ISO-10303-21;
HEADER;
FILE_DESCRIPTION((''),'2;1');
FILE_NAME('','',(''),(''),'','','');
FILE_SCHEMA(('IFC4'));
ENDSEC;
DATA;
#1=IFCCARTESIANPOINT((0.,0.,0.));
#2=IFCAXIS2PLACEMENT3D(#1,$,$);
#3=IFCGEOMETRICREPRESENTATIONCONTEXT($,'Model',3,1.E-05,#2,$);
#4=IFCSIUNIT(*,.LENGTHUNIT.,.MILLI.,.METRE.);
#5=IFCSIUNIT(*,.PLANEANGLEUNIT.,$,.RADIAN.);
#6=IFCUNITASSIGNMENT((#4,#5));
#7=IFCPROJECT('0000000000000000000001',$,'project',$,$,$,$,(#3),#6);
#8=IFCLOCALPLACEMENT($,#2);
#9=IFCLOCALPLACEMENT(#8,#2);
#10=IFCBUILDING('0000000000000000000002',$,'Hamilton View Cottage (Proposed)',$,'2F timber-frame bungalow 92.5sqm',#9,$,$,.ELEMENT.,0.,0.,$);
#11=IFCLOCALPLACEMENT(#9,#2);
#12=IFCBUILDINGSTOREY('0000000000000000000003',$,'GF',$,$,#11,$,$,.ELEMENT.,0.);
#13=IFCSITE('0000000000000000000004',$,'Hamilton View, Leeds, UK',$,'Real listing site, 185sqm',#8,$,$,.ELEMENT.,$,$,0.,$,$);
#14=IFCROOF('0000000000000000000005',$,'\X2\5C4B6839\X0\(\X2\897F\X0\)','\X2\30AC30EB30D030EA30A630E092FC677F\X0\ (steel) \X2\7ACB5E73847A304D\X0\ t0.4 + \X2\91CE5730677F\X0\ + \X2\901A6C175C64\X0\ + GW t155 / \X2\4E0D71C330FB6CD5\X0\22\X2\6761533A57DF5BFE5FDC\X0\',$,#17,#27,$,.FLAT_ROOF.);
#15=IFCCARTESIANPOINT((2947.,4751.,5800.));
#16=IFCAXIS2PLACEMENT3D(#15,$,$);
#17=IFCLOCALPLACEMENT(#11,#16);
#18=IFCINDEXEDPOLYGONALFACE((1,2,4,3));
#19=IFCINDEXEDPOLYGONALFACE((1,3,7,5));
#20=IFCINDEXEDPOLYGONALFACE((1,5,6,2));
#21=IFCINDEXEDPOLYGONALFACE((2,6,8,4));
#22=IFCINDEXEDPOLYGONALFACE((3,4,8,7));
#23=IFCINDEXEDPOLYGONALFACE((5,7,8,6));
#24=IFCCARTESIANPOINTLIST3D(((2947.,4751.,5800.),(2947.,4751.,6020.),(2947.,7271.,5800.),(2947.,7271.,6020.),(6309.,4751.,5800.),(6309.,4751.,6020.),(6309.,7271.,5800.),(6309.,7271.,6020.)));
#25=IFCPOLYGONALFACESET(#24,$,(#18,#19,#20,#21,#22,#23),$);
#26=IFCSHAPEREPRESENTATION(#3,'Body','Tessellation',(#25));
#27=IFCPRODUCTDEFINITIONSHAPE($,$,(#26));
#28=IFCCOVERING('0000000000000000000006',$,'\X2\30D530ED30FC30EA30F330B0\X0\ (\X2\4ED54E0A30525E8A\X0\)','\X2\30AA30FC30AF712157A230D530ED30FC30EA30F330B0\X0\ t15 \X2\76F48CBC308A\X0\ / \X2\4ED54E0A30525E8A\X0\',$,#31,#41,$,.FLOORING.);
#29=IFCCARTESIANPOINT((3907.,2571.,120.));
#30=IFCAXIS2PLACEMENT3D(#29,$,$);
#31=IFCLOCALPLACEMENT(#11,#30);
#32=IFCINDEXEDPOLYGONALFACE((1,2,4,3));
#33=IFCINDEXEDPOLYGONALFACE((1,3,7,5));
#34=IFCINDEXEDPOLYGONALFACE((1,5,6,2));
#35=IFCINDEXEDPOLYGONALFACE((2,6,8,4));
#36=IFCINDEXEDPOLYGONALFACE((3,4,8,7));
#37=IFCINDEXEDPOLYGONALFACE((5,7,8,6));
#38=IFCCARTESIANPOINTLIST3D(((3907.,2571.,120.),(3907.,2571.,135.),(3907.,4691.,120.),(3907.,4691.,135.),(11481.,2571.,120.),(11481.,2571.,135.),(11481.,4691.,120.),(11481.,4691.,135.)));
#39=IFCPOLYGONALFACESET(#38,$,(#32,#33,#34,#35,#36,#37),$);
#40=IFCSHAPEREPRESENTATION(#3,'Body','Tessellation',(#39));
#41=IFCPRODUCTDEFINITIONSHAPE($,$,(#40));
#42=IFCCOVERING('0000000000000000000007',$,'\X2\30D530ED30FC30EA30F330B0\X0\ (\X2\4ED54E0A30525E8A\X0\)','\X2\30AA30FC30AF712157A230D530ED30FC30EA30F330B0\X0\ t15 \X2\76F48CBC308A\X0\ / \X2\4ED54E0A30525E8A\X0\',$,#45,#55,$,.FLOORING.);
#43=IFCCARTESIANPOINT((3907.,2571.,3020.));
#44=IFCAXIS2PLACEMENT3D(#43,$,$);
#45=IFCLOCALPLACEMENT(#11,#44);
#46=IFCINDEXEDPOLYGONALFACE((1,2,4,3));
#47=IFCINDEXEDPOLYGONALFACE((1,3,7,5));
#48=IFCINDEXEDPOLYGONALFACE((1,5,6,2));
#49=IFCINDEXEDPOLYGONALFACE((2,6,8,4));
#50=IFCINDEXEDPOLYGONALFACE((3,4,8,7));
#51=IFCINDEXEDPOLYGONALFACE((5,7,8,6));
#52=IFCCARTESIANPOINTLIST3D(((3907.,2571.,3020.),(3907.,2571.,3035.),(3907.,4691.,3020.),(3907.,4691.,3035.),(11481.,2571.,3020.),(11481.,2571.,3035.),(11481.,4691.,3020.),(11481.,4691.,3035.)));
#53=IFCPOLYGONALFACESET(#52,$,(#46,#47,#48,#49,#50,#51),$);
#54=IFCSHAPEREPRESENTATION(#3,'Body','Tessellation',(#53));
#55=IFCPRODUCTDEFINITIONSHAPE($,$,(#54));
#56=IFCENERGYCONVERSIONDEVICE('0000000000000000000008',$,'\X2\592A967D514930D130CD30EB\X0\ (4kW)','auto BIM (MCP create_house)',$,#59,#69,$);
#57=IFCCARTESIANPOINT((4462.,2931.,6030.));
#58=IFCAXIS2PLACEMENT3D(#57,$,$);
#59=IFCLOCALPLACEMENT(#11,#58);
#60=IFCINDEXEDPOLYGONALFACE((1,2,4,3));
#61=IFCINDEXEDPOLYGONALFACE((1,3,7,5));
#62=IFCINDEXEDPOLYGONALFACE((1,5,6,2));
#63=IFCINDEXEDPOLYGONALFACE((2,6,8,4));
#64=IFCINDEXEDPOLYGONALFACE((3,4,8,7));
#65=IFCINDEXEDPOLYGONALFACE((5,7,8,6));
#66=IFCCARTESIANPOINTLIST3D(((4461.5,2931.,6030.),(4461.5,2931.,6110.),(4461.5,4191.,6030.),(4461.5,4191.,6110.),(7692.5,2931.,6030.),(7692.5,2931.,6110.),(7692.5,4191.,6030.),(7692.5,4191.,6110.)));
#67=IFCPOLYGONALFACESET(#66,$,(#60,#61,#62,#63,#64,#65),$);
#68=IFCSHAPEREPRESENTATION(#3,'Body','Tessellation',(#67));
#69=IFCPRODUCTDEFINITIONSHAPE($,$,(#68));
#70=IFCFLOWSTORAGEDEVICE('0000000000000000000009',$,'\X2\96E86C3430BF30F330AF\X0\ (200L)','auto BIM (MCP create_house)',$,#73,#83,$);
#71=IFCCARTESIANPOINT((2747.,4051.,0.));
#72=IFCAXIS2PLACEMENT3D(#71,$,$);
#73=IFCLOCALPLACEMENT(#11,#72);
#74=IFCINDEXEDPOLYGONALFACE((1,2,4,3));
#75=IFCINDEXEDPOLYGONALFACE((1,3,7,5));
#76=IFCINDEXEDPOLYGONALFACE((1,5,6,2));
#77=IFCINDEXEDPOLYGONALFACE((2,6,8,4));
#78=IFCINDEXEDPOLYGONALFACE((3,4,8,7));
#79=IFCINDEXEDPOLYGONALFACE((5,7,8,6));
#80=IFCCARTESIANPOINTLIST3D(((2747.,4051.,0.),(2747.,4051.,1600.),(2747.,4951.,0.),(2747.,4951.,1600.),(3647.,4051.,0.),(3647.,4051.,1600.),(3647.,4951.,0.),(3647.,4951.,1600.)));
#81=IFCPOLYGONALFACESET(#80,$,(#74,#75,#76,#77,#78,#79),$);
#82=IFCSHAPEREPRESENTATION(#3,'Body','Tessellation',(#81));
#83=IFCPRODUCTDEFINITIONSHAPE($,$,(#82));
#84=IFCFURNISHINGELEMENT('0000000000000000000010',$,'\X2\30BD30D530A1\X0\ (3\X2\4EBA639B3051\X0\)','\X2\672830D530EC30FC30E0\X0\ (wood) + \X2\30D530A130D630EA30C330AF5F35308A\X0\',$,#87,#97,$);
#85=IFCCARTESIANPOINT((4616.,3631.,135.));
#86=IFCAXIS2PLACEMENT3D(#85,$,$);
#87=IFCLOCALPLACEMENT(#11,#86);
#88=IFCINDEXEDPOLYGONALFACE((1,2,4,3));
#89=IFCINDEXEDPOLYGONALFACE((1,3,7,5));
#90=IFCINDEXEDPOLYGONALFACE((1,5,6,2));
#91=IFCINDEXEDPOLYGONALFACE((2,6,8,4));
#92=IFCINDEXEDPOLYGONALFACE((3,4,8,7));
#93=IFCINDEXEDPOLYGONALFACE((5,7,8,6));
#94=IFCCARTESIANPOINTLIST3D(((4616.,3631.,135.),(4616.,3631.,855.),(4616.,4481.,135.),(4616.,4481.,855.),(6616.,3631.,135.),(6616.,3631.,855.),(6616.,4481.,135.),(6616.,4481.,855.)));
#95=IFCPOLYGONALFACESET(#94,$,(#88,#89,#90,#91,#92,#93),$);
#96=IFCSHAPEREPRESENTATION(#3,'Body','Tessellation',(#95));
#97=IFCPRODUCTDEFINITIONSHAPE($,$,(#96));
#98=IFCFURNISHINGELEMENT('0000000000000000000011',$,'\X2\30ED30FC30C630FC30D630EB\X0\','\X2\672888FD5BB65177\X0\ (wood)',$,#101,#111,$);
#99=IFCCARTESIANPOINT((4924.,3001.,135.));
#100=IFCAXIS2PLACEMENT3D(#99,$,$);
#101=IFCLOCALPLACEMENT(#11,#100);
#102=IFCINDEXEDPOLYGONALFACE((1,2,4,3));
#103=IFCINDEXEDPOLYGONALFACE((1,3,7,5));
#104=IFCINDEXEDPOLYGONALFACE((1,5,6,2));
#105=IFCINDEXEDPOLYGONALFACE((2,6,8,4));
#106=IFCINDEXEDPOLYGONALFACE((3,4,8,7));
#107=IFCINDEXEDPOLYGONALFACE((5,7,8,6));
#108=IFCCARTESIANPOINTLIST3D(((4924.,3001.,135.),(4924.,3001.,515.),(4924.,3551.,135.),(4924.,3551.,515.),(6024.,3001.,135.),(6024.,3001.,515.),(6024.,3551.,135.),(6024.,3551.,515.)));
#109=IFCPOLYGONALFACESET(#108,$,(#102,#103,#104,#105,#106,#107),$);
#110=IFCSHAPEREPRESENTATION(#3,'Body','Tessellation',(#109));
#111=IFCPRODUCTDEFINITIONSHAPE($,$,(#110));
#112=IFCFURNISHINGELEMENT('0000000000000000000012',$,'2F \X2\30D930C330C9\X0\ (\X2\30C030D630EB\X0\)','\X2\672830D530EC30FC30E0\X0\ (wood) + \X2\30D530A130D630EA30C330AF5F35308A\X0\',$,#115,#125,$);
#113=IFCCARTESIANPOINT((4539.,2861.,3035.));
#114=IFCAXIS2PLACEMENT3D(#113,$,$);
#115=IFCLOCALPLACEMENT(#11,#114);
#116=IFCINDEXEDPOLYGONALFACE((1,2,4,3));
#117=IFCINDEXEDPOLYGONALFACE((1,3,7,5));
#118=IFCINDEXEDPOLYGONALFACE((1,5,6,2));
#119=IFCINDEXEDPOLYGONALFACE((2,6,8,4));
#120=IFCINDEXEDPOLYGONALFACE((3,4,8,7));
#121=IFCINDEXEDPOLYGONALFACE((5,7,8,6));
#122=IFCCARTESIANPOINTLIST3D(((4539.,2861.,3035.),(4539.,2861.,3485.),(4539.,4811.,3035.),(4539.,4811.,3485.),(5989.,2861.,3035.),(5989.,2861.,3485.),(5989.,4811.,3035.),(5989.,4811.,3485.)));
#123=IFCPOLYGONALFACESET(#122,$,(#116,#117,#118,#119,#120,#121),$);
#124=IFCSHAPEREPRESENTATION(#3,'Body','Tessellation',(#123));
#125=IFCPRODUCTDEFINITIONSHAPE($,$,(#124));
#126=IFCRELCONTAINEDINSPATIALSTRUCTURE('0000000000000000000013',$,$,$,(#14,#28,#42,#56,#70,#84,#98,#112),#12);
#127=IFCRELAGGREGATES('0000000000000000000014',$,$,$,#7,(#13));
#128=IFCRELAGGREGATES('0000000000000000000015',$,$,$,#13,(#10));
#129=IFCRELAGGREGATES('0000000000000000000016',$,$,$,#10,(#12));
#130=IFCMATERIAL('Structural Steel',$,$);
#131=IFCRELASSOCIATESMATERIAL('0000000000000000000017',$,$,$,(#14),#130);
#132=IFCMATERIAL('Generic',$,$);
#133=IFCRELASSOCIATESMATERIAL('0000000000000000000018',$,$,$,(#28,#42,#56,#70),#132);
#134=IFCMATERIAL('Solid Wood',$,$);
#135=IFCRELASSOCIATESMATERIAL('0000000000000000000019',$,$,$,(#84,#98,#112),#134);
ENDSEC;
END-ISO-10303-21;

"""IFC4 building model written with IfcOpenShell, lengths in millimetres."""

from ifc_helpers import new_model, si_unit, frame, frame_2d, origin, place, context, project, spatial, rectangle, extrude, material, element, save


model = new_model("IFC4")

# Units and contexts
model_context = context("Model", 3, precision=1e-05, world=origin())
ifc_project = project(units=[si_unit("LENGTHUNIT", "METRE", prefix="MILLI"), si_unit("PLANEANGLEUNIT", "RADIAN")], contexts=[model_context])

# Site, building, storey
site_placement = place(None, origin())
site = spatial("IfcSite", under=ifc_project, at=site_placement, Name="Hamilton View, Leeds, UK", ObjectType="Real listing site, 185sqm", CompositionType="ELEMENT", RefElevation=0.0)
building_placement = place(site_placement, origin())
building = spatial("IfcBuilding", under=site, at=building_placement, Name="Hamilton View Cottage (Proposed)", ObjectType="2F timber-frame bungalow 92.5sqm", CompositionType="ELEMENT", ElevationOfRefHeight=0.0, ElevationOfTerrain=0.0)
storey_placement = place(building_placement, origin())
storey = spatial("IfcBuildingStorey", under=building, at=storey_placement, Name="GF", CompositionType="ELEMENT", Elevation=0.0)

# Shared definitions
ifc_material_1 = material(Name="Solid Wood")

# Roof
ifc_material_2 = material(Name="Structural Steel")
roof_1_placement = place(storey_placement, frame((2947.0, 4751.0, 5800.0)))
element("IfcRoof", 1, at=roof_1_placement, inside=storey, material=ifc_material_2, Name="屋根(西)", Description="ガルバリウム鋼板 (steel) 立平葺き t0.4 + 野地板 + 通気層 + GW t155 / 不燃・法22条区域対応", PredefinedType="FLAT_ROOF", context=model_context, shape_type="SweptSolid", body=[
    extrude(rectangle(XDim=3362.0, YDim=2520.0, at=frame_2d((1681.0, 1260.0))), frame((2947.0, 4751.0, 5800.0)), (0.0, 0.0, 1.0), 220.0),
])

# Coverings
ifc_material_3 = material(Name="Generic")
covering_1_placement = place(storey_placement, frame((3907.0, 2571.0, 120.0)))
element("IfcCovering", 2, at=covering_1_placement, inside=storey, material=ifc_material_3, Name="フローリング (仕上げ床)", Description="オーク無垢フローリング t15 直貼り / 仕上げ床", PredefinedType="FLOORING", context=model_context, shape_type="SweptSolid", body=[
    extrude(rectangle(XDim=7574.0, YDim=2120.0, at=frame_2d((3787.0, 1060.0))), frame((3907.0, 2571.0, 120.0)), (0.0, 0.0, 1.0), 15.0),
])
covering_2_placement = place(storey_placement, frame((3907.0, 2571.0, 3020.0)))
element("IfcCovering", 3, at=covering_2_placement, inside=storey, material=ifc_material_3, Name="フローリング (仕上げ床)", Description="オーク無垢フローリング t15 直貼り / 仕上げ床", PredefinedType="FLOORING", context=model_context, shape_type="SweptSolid", body=[
    extrude(rectangle(XDim=7574.0, YDim=2120.0, at=frame_2d((3787.0, 1060.0))), frame((3907.0, 2571.0, 3020.0)), (0.0, 0.0, 1.0), 15.0),
])

# Energy conversion device
energy_conversion_device_placement = place(storey_placement, frame((4462.0, 2931.0, 6030.0)))
element("IfcEnergyConversionDevice", 4, at=energy_conversion_device_placement, inside=storey, material=ifc_material_3, Name="太陽光パネル (4kW)", Description="auto BIM (MCP create_house)", context=model_context, shape_type="SweptSolid", body=[
    extrude(rectangle(XDim=3231.0, YDim=1260.0, at=frame_2d((1615.0, 630.0))), frame((4462.0, 2931.0, 6030.0)), (0.0, 0.0, 1.0), 80.0),
])

# Flow storage device
flow_storage_device_placement = place(storey_placement, frame((2747.0, 4051.0, 0.0)))
element("IfcFlowStorageDevice", 5, at=flow_storage_device_placement, inside=storey, material=ifc_material_3, Name="雨水タンク (200L)", Description="auto BIM (MCP create_house)", context=model_context, shape_type="SweptSolid", body=[
    extrude(rectangle(XDim=900.0, YDim=900.0, at=frame_2d((450.0, 450.0))), frame((2747.0, 4051.0, 0.0)), (0.0, 0.0, 1.0), 1600.0),
])

# Furnishing elements
furnishing_1_placement = place(storey_placement, frame((4616.0, 3631.0, 135.0)))
element("IfcFurnishingElement", 6, at=furnishing_1_placement, inside=storey, material=ifc_material_1, Name="ソファ (3人掛け)", Description="木フレーム (wood) + ファブリック張り", context=model_context, shape_type="SweptSolid", body=[
    extrude(rectangle(XDim=2000.0, YDim=850.0, at=frame_2d((1000.0, 425.0))), frame((4616.0, 3631.0, 135.0)), (0.0, 0.0, 1.0), 720.0),
])
furnishing_2_placement = place(storey_placement, frame((4924.0, 3001.0, 135.0)))
element("IfcFurnishingElement", 7, at=furnishing_2_placement, inside=storey, material=ifc_material_1, Name="ローテーブル", Description="木製家具 (wood)", context=model_context, shape_type="SweptSolid", body=[
    extrude(rectangle(XDim=1100.0, YDim=550.0, at=frame_2d((550.0, 275.0))), frame((4924.0, 3001.0, 135.0)), (0.0, 0.0, 1.0), 380.0),
])
furnishing_3_placement = place(storey_placement, frame((4539.0, 2861.0, 3035.0)))
element("IfcFurnishingElement", 8, at=furnishing_3_placement, inside=storey, material=ifc_material_1, Name="2F ベッド (ダブル)", Description="木フレーム (wood) + ファブリック張り", context=model_context, shape_type="SweptSolid", body=[
    extrude(rectangle(XDim=1450.0, YDim=1950.0, at=frame_2d((725.0, 975.0))), frame((4539.0, 2861.0, 3035.0)), (0.0, 0.0, 1.0), 450.0),
])

save(model, "model.ifc")
